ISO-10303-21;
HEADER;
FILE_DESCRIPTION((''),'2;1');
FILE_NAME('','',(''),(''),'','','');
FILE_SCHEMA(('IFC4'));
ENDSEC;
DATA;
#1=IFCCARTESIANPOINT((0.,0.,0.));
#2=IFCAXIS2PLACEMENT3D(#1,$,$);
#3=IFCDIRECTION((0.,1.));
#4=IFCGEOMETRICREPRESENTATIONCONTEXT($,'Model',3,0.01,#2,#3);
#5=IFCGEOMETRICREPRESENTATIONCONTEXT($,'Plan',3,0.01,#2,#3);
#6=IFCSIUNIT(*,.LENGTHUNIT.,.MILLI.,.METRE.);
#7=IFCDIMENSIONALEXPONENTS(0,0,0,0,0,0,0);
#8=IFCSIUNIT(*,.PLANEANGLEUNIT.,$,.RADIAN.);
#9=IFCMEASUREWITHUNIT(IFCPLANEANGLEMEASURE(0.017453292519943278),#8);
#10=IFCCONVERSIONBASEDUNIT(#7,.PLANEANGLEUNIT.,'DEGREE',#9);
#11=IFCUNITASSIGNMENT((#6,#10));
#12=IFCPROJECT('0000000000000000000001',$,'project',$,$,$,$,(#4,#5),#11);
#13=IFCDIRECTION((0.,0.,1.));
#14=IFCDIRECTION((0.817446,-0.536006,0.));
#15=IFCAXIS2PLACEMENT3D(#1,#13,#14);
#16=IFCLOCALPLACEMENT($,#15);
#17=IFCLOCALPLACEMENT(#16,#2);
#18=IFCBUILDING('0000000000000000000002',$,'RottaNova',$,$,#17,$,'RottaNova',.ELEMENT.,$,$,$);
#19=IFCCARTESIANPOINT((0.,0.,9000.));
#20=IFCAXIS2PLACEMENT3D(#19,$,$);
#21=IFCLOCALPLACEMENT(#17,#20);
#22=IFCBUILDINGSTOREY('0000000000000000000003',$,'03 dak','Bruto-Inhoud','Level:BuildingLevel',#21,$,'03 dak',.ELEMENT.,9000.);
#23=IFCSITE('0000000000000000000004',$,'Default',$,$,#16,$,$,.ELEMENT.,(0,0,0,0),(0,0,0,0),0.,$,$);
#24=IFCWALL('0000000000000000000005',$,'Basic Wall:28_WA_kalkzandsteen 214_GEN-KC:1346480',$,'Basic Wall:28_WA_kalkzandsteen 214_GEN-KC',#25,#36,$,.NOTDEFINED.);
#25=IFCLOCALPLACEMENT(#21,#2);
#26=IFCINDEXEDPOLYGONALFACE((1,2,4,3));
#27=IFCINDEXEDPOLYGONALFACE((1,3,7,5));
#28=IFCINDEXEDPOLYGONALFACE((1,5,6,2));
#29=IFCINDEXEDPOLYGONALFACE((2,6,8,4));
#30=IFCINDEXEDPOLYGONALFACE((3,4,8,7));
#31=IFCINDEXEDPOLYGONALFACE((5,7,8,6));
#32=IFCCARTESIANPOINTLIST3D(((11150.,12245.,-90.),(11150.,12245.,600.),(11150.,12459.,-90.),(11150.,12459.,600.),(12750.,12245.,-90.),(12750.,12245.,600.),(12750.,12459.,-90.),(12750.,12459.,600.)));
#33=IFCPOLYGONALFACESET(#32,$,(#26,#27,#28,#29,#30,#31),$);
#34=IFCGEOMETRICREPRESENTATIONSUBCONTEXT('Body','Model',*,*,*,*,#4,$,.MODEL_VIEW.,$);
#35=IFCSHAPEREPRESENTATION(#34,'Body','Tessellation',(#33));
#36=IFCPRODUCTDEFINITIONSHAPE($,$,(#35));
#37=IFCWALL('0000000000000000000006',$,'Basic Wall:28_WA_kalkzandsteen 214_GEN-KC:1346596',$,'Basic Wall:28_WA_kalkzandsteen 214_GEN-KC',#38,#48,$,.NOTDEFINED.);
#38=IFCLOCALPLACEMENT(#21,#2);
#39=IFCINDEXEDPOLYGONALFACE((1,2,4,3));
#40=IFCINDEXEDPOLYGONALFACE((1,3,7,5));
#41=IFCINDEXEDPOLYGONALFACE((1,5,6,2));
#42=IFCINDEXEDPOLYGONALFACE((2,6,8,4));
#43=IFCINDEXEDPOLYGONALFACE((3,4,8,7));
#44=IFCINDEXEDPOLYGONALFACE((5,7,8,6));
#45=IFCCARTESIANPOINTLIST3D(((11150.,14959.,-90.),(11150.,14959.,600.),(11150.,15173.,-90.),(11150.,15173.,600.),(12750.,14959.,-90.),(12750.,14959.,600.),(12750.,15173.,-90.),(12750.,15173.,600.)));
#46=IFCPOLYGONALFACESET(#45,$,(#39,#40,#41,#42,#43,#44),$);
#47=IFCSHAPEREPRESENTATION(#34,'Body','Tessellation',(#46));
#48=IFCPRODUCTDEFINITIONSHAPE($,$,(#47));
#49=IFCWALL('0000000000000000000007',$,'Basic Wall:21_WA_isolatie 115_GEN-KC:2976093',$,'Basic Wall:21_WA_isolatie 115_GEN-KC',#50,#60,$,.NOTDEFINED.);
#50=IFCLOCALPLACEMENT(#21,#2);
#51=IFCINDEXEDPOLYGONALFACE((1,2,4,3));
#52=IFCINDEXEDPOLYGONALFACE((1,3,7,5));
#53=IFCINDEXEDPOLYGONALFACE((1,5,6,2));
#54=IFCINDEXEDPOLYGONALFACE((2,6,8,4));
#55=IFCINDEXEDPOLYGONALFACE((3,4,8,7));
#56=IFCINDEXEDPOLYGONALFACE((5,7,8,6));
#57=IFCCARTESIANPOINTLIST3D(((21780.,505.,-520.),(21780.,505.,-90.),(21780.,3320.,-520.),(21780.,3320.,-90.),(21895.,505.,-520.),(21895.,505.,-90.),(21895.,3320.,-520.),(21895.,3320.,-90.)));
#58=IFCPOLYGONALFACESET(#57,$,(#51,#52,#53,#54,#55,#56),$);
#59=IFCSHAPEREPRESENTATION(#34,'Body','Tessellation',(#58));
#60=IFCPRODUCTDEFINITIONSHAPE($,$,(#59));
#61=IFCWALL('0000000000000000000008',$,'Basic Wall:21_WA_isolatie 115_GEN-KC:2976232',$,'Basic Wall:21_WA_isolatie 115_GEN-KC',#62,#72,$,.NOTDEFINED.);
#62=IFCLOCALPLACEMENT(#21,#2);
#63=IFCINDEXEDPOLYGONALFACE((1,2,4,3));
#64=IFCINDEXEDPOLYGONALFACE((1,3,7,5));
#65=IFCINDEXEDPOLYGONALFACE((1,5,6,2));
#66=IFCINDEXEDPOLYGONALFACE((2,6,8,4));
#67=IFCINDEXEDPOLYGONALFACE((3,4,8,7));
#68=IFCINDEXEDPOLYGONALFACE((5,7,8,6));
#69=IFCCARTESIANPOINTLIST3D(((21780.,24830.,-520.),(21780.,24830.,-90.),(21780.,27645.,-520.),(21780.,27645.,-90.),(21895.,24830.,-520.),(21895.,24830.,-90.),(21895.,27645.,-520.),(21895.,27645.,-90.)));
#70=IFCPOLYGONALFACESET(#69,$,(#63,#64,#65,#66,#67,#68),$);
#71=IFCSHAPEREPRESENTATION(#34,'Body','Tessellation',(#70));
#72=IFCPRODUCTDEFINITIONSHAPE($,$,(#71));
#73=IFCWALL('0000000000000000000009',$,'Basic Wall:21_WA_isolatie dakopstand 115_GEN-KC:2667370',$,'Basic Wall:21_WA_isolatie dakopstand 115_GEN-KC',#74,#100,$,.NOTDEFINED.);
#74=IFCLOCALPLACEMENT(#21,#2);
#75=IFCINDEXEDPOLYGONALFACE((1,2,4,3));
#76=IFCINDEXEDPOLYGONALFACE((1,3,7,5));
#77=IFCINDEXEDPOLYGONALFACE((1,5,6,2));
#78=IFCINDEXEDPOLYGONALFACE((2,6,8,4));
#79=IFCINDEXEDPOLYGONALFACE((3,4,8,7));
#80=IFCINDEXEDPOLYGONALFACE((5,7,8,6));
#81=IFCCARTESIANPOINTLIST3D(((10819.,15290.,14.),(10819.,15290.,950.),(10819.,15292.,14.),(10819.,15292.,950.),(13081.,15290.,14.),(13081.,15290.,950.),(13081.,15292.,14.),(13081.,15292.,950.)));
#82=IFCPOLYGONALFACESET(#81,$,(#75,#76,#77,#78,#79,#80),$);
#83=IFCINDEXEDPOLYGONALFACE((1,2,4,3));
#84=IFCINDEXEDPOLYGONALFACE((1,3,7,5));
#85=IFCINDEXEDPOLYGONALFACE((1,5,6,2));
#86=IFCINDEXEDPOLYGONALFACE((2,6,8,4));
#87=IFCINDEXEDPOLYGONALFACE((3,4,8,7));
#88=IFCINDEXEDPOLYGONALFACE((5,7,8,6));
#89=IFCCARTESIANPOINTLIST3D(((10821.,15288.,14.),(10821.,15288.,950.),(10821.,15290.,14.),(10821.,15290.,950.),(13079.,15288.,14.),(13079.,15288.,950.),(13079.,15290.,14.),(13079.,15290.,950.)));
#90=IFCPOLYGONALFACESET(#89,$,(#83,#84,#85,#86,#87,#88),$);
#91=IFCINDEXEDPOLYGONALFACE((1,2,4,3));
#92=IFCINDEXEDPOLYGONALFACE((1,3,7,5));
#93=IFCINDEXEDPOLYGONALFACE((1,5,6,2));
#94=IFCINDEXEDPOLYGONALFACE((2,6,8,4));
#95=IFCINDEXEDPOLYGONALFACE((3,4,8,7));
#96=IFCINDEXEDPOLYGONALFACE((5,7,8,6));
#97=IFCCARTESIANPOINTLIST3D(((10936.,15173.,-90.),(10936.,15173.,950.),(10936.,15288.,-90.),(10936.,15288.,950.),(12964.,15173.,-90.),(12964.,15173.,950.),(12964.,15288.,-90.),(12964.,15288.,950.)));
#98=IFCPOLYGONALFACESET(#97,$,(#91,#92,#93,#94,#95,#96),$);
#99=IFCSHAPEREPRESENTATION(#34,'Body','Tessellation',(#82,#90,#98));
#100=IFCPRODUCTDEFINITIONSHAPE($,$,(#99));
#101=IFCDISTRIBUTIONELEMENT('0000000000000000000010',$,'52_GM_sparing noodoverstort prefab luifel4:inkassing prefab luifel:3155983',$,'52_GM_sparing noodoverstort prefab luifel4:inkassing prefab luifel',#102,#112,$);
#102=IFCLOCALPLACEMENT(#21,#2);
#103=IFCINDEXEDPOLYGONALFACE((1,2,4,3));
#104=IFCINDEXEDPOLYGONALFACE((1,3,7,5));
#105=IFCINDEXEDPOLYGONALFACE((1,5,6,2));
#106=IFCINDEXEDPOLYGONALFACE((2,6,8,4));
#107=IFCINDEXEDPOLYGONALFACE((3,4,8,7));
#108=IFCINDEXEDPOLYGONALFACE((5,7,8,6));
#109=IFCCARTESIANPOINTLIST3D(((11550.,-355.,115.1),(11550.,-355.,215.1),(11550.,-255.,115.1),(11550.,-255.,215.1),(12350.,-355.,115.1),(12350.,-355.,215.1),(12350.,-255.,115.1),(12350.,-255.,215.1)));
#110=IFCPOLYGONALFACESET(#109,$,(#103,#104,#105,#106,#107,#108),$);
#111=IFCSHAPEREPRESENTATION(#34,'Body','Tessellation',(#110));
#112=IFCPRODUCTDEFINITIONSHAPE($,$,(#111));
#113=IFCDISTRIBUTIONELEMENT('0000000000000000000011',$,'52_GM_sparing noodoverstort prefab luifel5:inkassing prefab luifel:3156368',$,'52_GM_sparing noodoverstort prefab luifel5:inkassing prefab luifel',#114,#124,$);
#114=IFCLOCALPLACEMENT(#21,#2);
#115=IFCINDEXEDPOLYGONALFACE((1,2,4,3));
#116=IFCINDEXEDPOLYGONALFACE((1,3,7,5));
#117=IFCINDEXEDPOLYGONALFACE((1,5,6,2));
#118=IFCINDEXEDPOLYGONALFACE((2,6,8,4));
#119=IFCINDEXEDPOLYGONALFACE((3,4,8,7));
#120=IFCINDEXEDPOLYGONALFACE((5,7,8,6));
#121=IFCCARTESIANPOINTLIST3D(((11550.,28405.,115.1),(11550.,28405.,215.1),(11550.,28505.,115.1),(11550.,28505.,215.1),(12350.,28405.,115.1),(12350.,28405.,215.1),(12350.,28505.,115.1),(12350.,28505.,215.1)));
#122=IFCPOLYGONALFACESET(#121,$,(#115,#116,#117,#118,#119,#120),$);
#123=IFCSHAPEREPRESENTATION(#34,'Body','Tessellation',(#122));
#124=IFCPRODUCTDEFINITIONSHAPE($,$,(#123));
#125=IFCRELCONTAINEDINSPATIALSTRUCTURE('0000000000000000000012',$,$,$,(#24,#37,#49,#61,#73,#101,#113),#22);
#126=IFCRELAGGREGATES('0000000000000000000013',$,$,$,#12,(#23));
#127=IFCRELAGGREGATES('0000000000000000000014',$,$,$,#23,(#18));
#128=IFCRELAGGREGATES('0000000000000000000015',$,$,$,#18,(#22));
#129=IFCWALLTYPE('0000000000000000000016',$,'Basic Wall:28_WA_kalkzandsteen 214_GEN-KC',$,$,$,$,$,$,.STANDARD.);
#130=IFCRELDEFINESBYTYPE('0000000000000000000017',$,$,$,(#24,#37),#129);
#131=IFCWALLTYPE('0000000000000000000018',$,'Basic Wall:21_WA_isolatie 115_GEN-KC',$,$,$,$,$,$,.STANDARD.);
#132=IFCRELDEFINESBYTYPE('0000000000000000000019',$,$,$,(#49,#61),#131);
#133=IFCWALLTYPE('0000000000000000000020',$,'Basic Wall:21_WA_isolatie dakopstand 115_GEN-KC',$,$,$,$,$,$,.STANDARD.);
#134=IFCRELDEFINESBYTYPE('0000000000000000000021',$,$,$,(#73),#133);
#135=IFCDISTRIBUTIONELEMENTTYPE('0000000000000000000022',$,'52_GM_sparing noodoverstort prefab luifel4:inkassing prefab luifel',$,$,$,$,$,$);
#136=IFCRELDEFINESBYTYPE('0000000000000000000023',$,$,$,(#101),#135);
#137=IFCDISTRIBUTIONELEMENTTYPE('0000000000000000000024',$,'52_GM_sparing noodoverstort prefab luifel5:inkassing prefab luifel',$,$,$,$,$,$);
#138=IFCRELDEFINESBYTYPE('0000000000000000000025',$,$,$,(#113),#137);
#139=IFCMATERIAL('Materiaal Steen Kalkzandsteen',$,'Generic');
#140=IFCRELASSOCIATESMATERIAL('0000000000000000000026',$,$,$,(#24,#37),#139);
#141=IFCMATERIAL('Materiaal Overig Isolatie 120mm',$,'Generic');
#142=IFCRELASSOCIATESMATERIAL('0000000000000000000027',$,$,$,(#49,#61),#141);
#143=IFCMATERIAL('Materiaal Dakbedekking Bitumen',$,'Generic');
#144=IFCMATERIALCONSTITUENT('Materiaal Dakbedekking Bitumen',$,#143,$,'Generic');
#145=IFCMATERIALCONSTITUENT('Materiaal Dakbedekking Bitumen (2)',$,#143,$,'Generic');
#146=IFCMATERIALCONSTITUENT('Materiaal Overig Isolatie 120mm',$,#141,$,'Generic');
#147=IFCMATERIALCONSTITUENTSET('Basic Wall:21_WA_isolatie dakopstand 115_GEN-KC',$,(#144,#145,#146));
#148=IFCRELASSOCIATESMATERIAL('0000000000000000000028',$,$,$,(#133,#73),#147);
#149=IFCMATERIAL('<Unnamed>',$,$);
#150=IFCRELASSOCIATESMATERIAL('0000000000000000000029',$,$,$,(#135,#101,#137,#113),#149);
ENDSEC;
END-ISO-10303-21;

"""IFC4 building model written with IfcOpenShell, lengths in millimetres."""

from ifc_helpers import new_model, entity, si_unit, converted_unit, direction, frame, origin, place, context, subcontext, project, spatial, indexed_curve, outline, extrude, source, transform, mapped, material, constituent, constituent_set, type_object, type_shapes, element, save


model = new_model("IFC4")

# Units and contexts
model_context = context("Model", 3, precision=0.01, world=origin(), true_north=direction((0.0, 1.0)))
plan_context = context("Plan", 3, precision=0.01, world=origin(), true_north=direction((0.0, 1.0)))
body_context = subcontext(model_context, "Body", "Model", "MODEL_VIEW")
ifc_project = project(units=[si_unit("LENGTHUNIT", "METRE", prefix="MILLI"), converted_unit("PLANEANGLEUNIT", "DEGREE", entity("IfcPlaneAngleMeasure", 0.017453292519943278), si_unit("PLANEANGLEUNIT", "RADIAN"), dimensions=[0, 0, 0, 0, 0, 0, 0])], contexts=[model_context, plan_context])

# Site, building, storey
site_placement = place(None, frame((0.0, 0.0, 0.0), z_axis=(0.0, 0.0, 1.0), x_axis=(0.817446, -0.536006, 0.0)))
site = spatial("IfcSite", under=ifc_project, at=site_placement, Name="Default", CompositionType="ELEMENT", RefLatitude=(0, 0, 0, 0), RefLongitude=(0, 0, 0, 0), RefElevation=0.0)
building_placement = place(site_placement, origin())
building = spatial("IfcBuilding", under=site, at=building_placement, Name="RottaNova", LongName="RottaNova", CompositionType="ELEMENT")
storey_placement = place(building_placement, frame((0.0, 0.0, 9000.0)))
storey = spatial("IfcBuildingStorey", under=building, at=storey_placement, Name="03 dak", Description="Bruto-Inhoud", ObjectType="Level:BuildingLevel", LongName="03 dak", CompositionType="ELEMENT", Elevation=9000.0)

# Shared definitions
ifc_material_1 = material(Name="Materiaal Dakbedekking Bitumen", Category="Generic")

# Walls
ifc_material_2 = material(Name="Materiaal Steen Kalkzandsteen", Category="Generic")
wall_type_1 = type_object("IfcWallType", Name="Basic Wall:28_WA_kalkzandsteen 214_GEN-KC", PredefinedType="STANDARD")
for number, where, name in (
    (1, (11150.0, 12352.0, -90.0), "Basic Wall:28_WA_kalkzandsteen 214_GEN-KC:1346480"),
    (2, (11150.0, 15066.0, -90.0), "Basic Wall:28_WA_kalkzandsteen 214_GEN-KC:1346596"),
):
    element("IfcWall", number, at=place(storey_placement, frame(where)), inside=storey, type_object=wall_type_1, material=ifc_material_2, Name=name, ObjectType="Basic Wall:28_WA_kalkzandsteen 214_GEN-KC", PredefinedType="NOTDEFINED", context=body_context, shape_type="SweptSolid", body=[
        extrude(outline(indexed_curve([(1600.0, 107.0), (0.0, 107.0), (0.0, -107.0), (1600.0, -107.0), (1600.0, 107.0)], self_intersect=False)), origin(), (0.0, 0.0, 1.0), 690.0),
    ])
ifc_material_3 = material(Name="Materiaal Overig Isolatie 120mm", Category="Generic")
wall_type_2 = type_object("IfcWallType", Name="Basic Wall:21_WA_isolatie 115_GEN-KC", PredefinedType="STANDARD")
wall_1_placement = place(storey_placement, frame((21837.5, 3320.0, -520.0), z_axis=(0.0, 0.0, 1.0), x_axis=(0.0, -1.0, 0.0)))
element("IfcWall", 3, at=wall_1_placement, inside=storey, type_object=wall_type_2, material=ifc_material_3, Name="Basic Wall:21_WA_isolatie 115_GEN-KC:2976093", ObjectType="Basic Wall:21_WA_isolatie 115_GEN-KC", PredefinedType="NOTDEFINED", context=body_context, shape_type="SweptSolid", body=[
    extrude(outline(indexed_curve([(2815.0, 57.5), (0.0, 57.5), (0.0, -57.5), (2815.0, -57.5), (2815.0, 57.5)], self_intersect=False)), origin(), (0.0, 0.0, 1.0), 430.0),
])
wall_2_placement = place(storey_placement, frame((21837.5, 24830.0, -520.0), z_axis=(0.0, 0.0, 1.0), x_axis=(0.0, 1.0, 0.0)))
element("IfcWall", 4, at=wall_2_placement, inside=storey, type_object=wall_type_2, material=ifc_material_3, Name="Basic Wall:21_WA_isolatie 115_GEN-KC:2976232", ObjectType="Basic Wall:21_WA_isolatie 115_GEN-KC", PredefinedType="NOTDEFINED", context=body_context, shape_type="SweptSolid", body=[
    extrude(outline(indexed_curve([(2815.0, 57.5), (0.0, 57.5), (0.0, -57.5), (2815.0, -57.5), (2815.0, 57.5)], self_intersect=False)), origin(), (0.0, 0.0, 1.0), 430.0),
])
ifc_constituent_1 = constituent(ifc_material_1, Name="Materiaal Dakbedekking Bitumen", Category="Generic")
ifc_constituent_2 = constituent(ifc_material_1, Name="Materiaal Dakbedekking Bitumen (2)", Category="Generic")
ifc_constituent_3 = constituent(ifc_material_3, Name="Materiaal Overig Isolatie 120mm", Category="Generic")
ifc_constituent_set_1 = constituent_set(constituents=[ifc_constituent_1, ifc_constituent_2, ifc_constituent_3], Name="Basic Wall:21_WA_isolatie dakopstand 115_GEN-KC")
wall_type_3 = type_object("IfcWallType", Name="Basic Wall:21_WA_isolatie dakopstand 115_GEN-KC", PredefinedType="STANDARD", material=ifc_constituent_set_1)
wall_3_placement = place(storey_placement, frame((10936.0, 15232.5, -90.0)))
element("IfcWall", 5, at=wall_3_placement, inside=storey, type_object=wall_type_3, material=ifc_constituent_set_1, Name="Basic Wall:21_WA_isolatie dakopstand 115_GEN-KC:2667370", ObjectType="Basic Wall:21_WA_isolatie dakopstand 115_GEN-KC", PredefinedType="NOTDEFINED", context=body_context, shape_type="SweptSolid", body=[
    extrude(outline(indexed_curve([(-1.0, -468.0), (1.0, -468.0), (1.0, 468.0), (-1.0, 468.0), (-1.0, -468.0)], self_intersect=False)), frame((-117.0, 58.5, 572.0), z_axis=(1.0, 0.0, 0.0), x_axis=(0.0, -1.0, 0.0)), (0.0, 0.0, 1.0), 2262.0),
    extrude(outline(indexed_curve([(-468.0, -1.0), (468.0, -1.0), (468.0, 1.0), (-468.0, 1.0), (-468.0, -1.0)], self_intersect=False)), frame((-115.0, 56.5, 572.0), z_axis=(1.0, 0.0, 0.0), x_axis=(0.0, 0.0, -1.0)), (0.0, 0.0, 1.0), 2258.0),
    extrude(outline(indexed_curve([(-57.5, -1014.0), (57.5, -1014.0), (57.5, 1014.0), (-57.5, 1014.0), (-57.5, -1014.0)], self_intersect=False)), frame((1014.0, -2.0, 0.0), z_axis=(0.0, 0.0, 1.0), x_axis=(0.0, 1.0, 0.0)), (0.0, 0.0, 1.0), 1040.0),
])

# Shared definitions
ifc_material_4 = material(Name="<Unnamed>")

# Distribution elements
distribution_element_type_1 = type_object("IfcDistributionElementType", Name="52_GM_sparing noodoverstort prefab luifel4:inkassing prefab luifel", material=ifc_material_4)
shared_shape_1 = source(origin(), body_context, "Body", "SweptSolid", [
    extrude(outline(indexed_curve([(-400.0, -50.0), (400.0, -50.0), (400.0, 50.0), (-400.0, 50.0), (-400.0, -50.0)], self_intersect=False)), frame((11950.0, -305.0, 9115.1)), (0.0, 0.0, 1.0), 100.0),
])
type_shapes(distribution_element_type_1, [shared_shape_1])
distribution_element_1_placement = place(storey_placement, frame((0.0, 0.0, -9000.0)))
element("IfcDistributionElement", 6, at=distribution_element_1_placement, inside=storey, type_object=distribution_element_type_1, material=ifc_material_4, Name="52_GM_sparing noodoverstort prefab luifel4:inkassing prefab luifel:3155983", ObjectType="52_GM_sparing noodoverstort prefab luifel4:inkassing prefab luifel", context=body_context, shape_type="MappedRepresentation", body=[
    mapped(shared_shape_1, transform((0.0, 0.0, 0.0), scale=1.0)),
])
distribution_element_type_2 = type_object("IfcDistributionElementType", Name="52_GM_sparing noodoverstort prefab luifel5:inkassing prefab luifel", material=ifc_material_4)
shared_shape_2 = source(origin(), body_context, "Body", "SweptSolid", [
    extrude(outline(indexed_curve([(-50.0, -400.0), (50.0, -400.0), (50.0, 400.0), (-50.0, 400.0), (-50.0, -400.0)], self_intersect=False)), frame((11950.0, 28455.0, 9115.1), z_axis=(0.0, 0.0, 1.0), x_axis=(0.0, -1.0, 0.0)), (0.0, 0.0, 1.0), 100.0),
])
type_shapes(distribution_element_type_2, [shared_shape_2])
distribution_element_2_placement = place(storey_placement, frame((0.0, 0.0, -9000.0)))
element("IfcDistributionElement", 7, at=distribution_element_2_placement, inside=storey, type_object=distribution_element_type_2, material=ifc_material_4, Name="52_GM_sparing noodoverstort prefab luifel5:inkassing prefab luifel:3156368", ObjectType="52_GM_sparing noodoverstort prefab luifel5:inkassing prefab luifel", context=body_context, shape_type="MappedRepresentation", body=[
    mapped(shared_shape_2, transform((0.0, 0.0, 0.0), scale=1.0)),
])

save(model, "model.ifc")
